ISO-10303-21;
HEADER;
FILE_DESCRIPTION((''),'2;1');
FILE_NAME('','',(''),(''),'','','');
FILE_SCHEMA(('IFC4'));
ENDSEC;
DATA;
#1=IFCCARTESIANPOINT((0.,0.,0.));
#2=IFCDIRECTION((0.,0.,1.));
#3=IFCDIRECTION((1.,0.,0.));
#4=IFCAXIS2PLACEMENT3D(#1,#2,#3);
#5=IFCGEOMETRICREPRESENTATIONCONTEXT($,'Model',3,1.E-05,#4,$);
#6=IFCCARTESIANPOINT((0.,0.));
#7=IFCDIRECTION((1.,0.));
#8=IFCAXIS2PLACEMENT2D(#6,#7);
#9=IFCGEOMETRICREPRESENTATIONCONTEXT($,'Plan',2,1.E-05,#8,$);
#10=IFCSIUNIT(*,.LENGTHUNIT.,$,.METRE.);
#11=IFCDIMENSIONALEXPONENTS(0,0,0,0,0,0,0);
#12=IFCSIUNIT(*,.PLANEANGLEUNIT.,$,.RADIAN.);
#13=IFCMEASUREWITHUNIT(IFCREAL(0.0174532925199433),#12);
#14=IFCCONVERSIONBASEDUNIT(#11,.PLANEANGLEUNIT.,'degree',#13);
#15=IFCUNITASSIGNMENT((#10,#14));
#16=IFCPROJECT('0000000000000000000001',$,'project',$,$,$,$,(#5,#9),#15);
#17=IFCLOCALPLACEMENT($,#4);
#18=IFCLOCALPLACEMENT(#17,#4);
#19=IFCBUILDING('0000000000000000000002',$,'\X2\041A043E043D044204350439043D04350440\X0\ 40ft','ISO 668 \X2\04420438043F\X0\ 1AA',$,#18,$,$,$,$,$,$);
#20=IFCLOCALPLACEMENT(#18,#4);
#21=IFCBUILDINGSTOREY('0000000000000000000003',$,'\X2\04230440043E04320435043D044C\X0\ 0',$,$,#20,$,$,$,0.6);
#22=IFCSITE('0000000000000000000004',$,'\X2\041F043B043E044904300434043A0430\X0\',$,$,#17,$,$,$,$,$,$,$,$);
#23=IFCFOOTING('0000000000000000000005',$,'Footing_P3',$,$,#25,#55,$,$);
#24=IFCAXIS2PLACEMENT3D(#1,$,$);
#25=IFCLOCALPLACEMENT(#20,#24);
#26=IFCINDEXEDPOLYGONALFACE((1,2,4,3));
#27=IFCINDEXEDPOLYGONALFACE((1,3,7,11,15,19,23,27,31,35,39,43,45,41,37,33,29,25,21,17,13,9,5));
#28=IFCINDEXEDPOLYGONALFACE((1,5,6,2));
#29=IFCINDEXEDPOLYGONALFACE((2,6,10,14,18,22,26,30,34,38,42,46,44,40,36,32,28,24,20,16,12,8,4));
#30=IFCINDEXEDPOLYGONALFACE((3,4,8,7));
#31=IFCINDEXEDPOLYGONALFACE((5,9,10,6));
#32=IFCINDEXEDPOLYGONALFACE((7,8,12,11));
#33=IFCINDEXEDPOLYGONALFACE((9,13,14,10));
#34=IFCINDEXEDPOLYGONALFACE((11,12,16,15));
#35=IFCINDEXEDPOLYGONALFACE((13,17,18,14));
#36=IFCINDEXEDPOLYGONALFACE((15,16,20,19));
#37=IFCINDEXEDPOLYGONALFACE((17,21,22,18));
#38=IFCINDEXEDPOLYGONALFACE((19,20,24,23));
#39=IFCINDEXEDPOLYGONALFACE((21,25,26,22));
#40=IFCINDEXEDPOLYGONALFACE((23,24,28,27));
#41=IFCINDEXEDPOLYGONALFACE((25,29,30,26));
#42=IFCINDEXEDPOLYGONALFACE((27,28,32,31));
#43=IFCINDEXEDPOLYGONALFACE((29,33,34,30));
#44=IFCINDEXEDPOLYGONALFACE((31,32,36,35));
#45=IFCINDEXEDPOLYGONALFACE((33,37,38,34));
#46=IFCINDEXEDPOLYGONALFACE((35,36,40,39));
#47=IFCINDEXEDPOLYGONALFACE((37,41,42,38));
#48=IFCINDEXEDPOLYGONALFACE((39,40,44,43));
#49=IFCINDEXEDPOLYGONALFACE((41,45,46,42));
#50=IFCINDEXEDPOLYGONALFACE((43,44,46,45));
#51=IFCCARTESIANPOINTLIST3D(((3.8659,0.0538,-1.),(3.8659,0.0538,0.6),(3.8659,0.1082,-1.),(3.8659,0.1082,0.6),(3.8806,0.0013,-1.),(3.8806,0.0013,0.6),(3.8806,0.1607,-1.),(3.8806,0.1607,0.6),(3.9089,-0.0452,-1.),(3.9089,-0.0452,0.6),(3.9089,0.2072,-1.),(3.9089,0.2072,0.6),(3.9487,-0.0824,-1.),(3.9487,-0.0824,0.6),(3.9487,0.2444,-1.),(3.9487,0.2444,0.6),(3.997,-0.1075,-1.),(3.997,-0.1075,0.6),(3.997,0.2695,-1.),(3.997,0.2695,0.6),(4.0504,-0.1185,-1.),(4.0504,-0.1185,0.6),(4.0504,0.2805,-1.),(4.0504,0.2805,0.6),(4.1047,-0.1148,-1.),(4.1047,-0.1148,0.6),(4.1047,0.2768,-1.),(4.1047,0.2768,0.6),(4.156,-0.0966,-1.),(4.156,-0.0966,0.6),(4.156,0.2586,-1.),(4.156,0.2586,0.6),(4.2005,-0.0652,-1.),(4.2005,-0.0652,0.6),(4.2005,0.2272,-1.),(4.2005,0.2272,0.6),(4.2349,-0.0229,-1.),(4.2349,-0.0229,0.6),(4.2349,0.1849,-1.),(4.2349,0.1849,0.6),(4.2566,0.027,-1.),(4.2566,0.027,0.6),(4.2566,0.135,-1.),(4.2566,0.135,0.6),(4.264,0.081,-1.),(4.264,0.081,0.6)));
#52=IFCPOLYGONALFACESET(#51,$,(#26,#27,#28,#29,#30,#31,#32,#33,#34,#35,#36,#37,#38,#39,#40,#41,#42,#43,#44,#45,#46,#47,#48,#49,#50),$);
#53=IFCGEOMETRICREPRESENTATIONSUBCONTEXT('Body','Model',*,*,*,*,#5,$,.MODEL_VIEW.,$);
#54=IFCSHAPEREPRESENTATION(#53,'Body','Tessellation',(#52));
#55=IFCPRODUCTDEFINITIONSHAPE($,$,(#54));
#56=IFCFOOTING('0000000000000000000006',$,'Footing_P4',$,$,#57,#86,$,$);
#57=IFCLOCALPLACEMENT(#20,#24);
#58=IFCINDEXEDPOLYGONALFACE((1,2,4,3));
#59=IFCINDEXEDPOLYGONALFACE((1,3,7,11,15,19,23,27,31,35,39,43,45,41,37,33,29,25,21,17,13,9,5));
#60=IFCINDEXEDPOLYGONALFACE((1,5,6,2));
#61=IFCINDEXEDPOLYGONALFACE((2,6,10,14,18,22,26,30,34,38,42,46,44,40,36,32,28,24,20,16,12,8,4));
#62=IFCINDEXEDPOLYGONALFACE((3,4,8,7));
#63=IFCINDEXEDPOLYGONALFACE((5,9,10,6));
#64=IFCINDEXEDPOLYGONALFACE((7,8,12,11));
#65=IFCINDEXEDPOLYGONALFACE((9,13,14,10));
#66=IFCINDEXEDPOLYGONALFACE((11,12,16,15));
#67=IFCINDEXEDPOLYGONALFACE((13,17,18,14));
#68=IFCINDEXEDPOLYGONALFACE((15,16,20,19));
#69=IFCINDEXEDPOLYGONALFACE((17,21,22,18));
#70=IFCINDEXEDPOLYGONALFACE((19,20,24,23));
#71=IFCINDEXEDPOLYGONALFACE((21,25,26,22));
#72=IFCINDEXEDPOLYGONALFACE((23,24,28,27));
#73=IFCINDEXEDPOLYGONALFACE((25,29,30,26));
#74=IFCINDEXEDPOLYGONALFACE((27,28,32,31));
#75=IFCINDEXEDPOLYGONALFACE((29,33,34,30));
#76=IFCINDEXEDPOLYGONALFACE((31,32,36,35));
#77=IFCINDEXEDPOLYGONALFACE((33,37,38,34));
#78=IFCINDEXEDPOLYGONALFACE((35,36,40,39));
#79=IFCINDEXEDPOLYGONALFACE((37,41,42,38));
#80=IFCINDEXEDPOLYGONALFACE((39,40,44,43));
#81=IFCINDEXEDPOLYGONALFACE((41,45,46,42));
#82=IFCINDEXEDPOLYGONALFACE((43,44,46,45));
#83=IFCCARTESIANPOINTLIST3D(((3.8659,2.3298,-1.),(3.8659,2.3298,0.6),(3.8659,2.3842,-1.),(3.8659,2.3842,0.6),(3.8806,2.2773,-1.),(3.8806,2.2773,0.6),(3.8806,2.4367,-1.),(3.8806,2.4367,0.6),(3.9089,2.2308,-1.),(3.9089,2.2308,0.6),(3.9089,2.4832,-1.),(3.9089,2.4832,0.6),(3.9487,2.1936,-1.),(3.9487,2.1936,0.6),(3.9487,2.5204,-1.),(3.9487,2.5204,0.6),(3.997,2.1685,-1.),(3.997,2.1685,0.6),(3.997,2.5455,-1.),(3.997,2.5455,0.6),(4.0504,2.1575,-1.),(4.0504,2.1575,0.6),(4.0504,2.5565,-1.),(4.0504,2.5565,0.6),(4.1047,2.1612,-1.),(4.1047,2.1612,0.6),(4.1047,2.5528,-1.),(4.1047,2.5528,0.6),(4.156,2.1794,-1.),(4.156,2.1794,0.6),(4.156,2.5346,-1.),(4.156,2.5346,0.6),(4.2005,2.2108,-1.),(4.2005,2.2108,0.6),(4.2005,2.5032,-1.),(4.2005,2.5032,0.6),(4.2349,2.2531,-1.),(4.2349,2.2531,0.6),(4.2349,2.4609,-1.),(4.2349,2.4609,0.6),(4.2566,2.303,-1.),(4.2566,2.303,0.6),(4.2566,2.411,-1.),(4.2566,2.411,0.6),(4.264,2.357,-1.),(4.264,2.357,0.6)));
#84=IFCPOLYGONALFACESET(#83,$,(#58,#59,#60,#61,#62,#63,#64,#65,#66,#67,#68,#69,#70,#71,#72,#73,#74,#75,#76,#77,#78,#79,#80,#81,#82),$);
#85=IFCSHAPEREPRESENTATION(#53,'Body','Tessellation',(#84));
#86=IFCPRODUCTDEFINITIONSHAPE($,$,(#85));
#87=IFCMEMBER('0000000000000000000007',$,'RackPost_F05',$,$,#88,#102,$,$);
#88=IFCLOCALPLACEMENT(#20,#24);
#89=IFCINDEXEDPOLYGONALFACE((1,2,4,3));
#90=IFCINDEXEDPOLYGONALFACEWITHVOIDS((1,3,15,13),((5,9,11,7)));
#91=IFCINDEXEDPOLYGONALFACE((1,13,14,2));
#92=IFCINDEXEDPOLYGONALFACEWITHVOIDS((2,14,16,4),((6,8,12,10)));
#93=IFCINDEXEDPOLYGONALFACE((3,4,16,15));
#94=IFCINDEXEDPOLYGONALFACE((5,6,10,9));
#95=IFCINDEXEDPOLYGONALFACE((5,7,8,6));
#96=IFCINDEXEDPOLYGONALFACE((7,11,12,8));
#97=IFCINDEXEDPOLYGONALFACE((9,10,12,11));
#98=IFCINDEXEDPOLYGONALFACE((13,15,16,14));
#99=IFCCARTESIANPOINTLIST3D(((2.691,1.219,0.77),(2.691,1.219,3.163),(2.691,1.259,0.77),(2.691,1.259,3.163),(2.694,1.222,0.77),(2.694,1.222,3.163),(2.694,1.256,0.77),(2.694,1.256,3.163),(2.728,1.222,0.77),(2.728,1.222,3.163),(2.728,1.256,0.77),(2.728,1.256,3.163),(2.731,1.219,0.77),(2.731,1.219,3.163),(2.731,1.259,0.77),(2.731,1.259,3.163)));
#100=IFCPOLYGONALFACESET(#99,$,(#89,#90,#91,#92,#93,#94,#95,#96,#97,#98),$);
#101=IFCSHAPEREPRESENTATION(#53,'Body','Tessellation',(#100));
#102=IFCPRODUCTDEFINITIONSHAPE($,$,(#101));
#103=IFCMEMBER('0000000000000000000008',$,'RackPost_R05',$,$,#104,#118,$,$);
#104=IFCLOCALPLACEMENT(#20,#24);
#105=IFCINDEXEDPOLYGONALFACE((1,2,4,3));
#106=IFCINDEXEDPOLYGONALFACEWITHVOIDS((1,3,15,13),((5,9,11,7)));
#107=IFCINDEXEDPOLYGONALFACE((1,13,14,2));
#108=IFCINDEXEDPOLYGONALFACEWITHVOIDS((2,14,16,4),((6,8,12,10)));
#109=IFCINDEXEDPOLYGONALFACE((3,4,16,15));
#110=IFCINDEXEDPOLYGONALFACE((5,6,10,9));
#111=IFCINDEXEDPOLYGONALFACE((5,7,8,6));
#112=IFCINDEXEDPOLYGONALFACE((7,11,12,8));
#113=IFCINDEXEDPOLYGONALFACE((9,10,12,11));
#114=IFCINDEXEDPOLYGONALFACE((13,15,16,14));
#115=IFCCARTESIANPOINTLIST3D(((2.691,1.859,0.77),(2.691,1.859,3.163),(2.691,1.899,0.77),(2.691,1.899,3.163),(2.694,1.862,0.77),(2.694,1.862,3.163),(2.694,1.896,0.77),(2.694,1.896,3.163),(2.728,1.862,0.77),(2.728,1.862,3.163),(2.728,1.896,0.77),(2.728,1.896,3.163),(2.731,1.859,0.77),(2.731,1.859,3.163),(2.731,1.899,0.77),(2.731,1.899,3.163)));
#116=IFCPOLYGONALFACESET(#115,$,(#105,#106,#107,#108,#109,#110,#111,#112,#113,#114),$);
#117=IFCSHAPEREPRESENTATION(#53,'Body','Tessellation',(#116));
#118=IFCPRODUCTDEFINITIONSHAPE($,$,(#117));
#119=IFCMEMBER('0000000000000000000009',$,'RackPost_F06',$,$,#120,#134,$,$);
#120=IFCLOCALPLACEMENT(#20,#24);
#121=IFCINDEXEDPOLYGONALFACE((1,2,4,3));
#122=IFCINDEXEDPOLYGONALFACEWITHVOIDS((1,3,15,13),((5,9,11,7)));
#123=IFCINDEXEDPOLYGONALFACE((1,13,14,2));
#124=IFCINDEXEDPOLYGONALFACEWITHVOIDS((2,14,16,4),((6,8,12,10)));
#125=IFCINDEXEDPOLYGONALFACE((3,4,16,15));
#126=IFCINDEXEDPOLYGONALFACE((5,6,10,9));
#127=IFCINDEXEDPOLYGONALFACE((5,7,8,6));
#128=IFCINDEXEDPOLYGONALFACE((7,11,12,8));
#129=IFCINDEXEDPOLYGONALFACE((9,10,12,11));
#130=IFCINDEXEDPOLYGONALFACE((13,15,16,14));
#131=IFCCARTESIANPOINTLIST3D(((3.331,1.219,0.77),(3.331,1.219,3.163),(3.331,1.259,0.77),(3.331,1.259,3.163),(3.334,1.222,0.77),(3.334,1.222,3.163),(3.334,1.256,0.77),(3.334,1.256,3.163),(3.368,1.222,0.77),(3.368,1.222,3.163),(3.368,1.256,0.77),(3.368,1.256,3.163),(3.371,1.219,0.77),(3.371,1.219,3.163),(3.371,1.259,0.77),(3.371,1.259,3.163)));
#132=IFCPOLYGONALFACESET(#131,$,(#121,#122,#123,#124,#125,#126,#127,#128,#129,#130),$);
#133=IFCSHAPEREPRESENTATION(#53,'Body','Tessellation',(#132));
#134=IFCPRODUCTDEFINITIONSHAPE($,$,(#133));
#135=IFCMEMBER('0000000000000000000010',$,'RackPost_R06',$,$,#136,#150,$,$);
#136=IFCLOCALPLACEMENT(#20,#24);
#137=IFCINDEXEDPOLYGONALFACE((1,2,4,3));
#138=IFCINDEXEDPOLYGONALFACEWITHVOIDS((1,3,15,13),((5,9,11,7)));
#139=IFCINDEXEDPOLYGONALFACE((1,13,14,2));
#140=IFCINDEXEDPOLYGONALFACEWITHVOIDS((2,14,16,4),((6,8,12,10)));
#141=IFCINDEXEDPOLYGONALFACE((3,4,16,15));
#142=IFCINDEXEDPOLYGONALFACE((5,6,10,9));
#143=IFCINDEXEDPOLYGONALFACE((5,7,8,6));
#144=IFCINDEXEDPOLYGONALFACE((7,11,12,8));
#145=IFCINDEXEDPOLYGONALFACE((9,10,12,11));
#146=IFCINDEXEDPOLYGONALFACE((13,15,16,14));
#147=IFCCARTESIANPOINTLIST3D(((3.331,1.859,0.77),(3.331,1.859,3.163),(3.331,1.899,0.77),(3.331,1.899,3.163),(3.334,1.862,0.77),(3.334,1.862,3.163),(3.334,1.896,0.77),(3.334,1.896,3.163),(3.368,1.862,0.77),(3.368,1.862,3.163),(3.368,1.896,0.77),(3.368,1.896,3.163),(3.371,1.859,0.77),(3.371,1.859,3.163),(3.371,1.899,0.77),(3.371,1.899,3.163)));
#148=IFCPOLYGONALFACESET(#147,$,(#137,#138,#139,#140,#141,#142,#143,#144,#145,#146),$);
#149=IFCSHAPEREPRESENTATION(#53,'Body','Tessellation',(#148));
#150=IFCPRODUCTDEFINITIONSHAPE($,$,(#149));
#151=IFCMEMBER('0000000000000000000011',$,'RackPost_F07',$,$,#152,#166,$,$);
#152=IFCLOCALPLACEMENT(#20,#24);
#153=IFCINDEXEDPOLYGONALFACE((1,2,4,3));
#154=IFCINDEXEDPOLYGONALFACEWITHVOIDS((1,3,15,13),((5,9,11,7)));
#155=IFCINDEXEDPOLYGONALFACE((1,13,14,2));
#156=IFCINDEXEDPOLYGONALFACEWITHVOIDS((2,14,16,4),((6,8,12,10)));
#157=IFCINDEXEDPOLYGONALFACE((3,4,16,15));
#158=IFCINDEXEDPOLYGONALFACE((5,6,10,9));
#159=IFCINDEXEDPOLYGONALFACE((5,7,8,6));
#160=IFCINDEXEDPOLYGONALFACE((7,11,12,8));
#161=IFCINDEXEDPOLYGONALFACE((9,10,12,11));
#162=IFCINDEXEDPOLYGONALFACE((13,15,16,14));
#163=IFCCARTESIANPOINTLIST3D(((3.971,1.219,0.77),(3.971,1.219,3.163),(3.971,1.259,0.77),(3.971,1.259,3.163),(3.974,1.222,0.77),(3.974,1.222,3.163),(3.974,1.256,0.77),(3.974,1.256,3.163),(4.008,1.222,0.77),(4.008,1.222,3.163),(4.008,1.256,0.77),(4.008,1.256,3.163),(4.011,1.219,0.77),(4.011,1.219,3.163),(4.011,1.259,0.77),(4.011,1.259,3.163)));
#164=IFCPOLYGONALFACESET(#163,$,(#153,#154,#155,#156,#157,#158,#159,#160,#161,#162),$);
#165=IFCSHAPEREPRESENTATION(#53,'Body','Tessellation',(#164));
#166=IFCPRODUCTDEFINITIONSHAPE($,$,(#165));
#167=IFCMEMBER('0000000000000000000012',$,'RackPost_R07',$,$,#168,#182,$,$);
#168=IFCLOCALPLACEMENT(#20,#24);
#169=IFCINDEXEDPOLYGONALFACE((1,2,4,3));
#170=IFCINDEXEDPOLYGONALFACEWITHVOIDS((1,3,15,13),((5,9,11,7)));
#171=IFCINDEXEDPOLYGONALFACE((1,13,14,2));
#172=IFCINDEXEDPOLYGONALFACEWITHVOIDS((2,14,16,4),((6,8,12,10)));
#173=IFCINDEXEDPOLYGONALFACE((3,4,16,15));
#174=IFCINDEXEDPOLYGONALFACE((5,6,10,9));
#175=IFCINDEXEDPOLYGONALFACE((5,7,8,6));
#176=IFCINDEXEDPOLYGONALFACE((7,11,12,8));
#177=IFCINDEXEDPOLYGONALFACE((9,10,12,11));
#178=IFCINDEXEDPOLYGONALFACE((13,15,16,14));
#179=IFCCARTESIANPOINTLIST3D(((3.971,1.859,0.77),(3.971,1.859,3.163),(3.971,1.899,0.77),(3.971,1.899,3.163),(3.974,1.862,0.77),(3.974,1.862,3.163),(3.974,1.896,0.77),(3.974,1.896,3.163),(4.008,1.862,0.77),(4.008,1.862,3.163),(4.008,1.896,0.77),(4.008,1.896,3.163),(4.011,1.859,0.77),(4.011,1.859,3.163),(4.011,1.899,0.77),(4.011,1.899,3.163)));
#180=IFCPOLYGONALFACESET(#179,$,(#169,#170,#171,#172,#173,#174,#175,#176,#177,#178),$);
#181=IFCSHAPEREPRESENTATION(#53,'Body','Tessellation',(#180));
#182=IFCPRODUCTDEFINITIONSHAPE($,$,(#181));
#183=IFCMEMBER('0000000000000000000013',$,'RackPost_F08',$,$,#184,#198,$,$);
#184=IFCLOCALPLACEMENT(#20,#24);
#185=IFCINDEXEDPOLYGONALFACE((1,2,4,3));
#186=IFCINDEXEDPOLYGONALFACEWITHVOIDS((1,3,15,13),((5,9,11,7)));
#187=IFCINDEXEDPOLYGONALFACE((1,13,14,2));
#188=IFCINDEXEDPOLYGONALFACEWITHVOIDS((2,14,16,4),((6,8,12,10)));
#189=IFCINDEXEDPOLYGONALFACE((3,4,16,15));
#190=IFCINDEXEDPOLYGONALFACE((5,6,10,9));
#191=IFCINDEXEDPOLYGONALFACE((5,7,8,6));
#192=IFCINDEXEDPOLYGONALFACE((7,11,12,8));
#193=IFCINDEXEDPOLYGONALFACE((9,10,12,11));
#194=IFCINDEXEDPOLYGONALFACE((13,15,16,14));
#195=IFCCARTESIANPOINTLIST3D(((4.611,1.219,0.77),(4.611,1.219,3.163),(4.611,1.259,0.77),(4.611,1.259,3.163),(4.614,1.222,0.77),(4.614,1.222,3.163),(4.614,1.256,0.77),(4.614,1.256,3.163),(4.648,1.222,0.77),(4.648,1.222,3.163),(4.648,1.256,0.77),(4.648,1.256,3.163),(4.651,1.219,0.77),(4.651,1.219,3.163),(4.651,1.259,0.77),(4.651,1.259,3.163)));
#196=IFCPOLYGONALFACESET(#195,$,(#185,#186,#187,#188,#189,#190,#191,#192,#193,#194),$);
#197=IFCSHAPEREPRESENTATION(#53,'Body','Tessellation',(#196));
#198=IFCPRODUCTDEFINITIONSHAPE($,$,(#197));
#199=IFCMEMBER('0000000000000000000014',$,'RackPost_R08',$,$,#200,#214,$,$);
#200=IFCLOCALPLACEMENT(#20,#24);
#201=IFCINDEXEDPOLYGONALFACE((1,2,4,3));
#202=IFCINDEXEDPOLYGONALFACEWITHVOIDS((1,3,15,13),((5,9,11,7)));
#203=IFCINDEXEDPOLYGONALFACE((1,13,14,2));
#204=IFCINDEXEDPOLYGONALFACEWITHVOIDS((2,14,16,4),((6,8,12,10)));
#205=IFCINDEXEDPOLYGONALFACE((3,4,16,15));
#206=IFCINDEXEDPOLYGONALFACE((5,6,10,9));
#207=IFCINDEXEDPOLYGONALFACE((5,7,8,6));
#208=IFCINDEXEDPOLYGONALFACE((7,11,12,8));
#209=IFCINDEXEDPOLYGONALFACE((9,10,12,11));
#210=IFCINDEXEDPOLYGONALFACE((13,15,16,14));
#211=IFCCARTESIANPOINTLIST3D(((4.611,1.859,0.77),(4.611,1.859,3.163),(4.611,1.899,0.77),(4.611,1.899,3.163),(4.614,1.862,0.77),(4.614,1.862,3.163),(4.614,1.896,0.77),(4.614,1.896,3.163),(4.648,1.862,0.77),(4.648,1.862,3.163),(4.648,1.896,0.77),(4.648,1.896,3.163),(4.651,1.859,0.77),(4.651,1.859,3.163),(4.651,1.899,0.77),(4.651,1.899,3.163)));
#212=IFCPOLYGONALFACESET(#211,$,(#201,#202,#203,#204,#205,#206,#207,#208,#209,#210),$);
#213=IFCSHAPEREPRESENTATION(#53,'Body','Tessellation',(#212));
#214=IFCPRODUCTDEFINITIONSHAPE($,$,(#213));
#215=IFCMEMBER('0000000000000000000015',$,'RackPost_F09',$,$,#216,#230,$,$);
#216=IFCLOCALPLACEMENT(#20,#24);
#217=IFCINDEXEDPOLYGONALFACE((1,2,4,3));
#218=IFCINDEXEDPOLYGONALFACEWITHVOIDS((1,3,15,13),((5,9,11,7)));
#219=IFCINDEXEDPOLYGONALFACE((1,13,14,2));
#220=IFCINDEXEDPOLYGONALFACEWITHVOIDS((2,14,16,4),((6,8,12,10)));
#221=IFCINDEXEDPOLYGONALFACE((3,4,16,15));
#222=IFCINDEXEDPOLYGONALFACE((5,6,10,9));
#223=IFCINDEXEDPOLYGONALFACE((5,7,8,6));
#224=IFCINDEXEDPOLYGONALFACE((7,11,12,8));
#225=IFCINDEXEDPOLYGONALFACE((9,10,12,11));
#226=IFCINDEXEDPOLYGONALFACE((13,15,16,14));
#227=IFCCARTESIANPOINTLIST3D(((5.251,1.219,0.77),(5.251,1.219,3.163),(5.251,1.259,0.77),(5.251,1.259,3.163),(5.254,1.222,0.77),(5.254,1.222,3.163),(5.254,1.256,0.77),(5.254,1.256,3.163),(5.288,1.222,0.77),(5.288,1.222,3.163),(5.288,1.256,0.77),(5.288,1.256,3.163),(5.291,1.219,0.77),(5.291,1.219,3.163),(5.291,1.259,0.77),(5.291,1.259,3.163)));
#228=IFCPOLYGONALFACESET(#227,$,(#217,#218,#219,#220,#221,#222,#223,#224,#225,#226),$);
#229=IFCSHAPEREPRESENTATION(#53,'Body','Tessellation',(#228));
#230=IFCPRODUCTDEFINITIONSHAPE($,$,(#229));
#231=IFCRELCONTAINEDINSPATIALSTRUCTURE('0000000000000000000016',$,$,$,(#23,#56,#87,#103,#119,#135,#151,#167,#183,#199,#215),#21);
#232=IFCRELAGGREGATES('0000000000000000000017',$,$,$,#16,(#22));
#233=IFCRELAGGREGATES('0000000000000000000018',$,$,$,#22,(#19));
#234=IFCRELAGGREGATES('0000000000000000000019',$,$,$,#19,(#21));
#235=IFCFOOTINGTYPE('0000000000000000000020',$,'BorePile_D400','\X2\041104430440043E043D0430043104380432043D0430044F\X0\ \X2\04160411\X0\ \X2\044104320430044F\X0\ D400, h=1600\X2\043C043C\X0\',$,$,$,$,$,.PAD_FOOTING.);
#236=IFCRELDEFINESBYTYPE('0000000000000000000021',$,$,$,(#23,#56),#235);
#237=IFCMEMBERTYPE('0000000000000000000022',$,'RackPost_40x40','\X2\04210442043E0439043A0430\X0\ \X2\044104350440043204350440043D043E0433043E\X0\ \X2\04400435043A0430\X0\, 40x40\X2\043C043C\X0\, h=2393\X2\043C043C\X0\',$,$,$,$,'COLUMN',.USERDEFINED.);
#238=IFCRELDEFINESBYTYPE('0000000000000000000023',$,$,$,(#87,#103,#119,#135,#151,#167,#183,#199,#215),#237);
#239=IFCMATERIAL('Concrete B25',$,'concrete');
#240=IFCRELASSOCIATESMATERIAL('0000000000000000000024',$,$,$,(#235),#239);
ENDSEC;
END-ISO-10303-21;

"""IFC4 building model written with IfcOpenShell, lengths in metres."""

from ifc_helpers import new_model, entity, si_unit, converted_unit, frame, origin_with_axes, origin_2d_with_axis, place, context, subcontext, project, spatial, hollow_rectangle, circle, extrude, material, type_object, element, save


model = new_model("IFC4")

# Units and contexts
model_context = context("Model", 3, precision=1e-05, world=origin_with_axes())
plan_context = context("Plan", 2, precision=1e-05, world=origin_2d_with_axis())
body_context = subcontext(model_context, "Body", "Model", "MODEL_VIEW")
ifc_project = project(units=[si_unit("LENGTHUNIT", "METRE"), converted_unit("PLANEANGLEUNIT", "degree", entity("IfcReal", 0.0174532925199433), si_unit("PLANEANGLEUNIT", "RADIAN"), dimensions=[0, 0, 0, 0, 0, 0, 0])], contexts=[model_context, plan_context])

# Site, building, storey
site_placement = place(None, origin_with_axes())
site = spatial("IfcSite", under=ifc_project, at=site_placement, Name="Площадка")
building_placement = place(site_placement, origin_with_axes())
building = spatial("IfcBuilding", under=site, at=building_placement, Name="Контейнер 40ft", Description="ISO 668 тип 1AA")
storey_placement = place(building_placement, origin_with_axes())
storey = spatial("IfcBuildingStorey", under=building, at=storey_placement, Name="Уровень 0", Elevation=0.6)

# Footings
ifc_material = material(Name="Concrete B25", Category="concrete")
footing_type = type_object("IfcFootingType", Name="BorePile_D400", Description="Буронабивная ЖБ свая D400, h=1600мм", PredefinedType="PAD_FOOTING", material=ifc_material)
for number, where, z_axis, x_axis, name in (
    (1, (4.064, 0.081, -1.0), (0.0, 0.0, 1.0), (1.0, 0.0, 0.0), "Footing_P3"),
    (2, (4.064, 2.357, -1.0), (0.0, 0.0, 1.0), (1.0, 0.0, 0.0), "Footing_P4"),
):
    element("IfcFooting", number, at=place(storey_placement, frame(where, z_axis=z_axis, x_axis=x_axis)), inside=storey, type_object=footing_type, Name=name, context=body_context, shape_type="SweptSolid", body=[
        extrude(circle(Radius=0.2), origin_with_axes(), (0.0, 0.0, 1.0), 1.6),
    ])

# Members
member_type = type_object("IfcMemberType", Name="RackPost_40x40", Description="Стойка серверного река, 40x40мм, h=2393мм", ElementType="COLUMN", PredefinedType="USERDEFINED")
for number, where, z_axis, x_axis, name in (
    (3, (2.711, 1.239, 0.77), (0.0, 0.0, 1.0), (1.0, 0.0, 0.0), "RackPost_F05"),
    (4, (2.711, 1.879, 0.77), (0.0, 0.0, 1.0), (1.0, 0.0, 0.0), "RackPost_R05"),
    (5, (3.351, 1.239, 0.77), (0.0, 0.0, 1.0), (1.0, 0.0, 0.0), "RackPost_F06"),
    (6, (3.351, 1.879, 0.77), (0.0, 0.0, 1.0), (1.0, 0.0, 0.0), "RackPost_R06"),
    (7, (3.991, 1.239, 0.77), (0.0, 0.0, 1.0), (1.0, 0.0, 0.0), "RackPost_F07"),
    (8, (3.991, 1.879, 0.77), (0.0, 0.0, 1.0), (1.0, 0.0, 0.0), "RackPost_R07"),
    (9, (4.631, 1.239, 0.77), (0.0, 0.0, 1.0), (1.0, 0.0, 0.0), "RackPost_F08"),
    (10, (4.631, 1.879, 0.77), (0.0, 0.0, 1.0), (1.0, 0.0, 0.0), "RackPost_R08"),
    (11, (5.271, 1.239, 0.77), (0.0, 0.0, 1.0), (1.0, 0.0, 0.0), "RackPost_F09"),
):
    element("IfcMember", number, at=place(storey_placement, frame(where, z_axis=z_axis, x_axis=x_axis)), inside=storey, type_object=member_type, Name=name, context=body_context, shape_type="SweptSolid", body=[
        extrude(hollow_rectangle(XDim=0.04, YDim=0.04, WallThickness=0.003), origin_with_axes(), (0.0, 0.0, 1.0), 2.393),
    ])

save(model, "model.ifc")
